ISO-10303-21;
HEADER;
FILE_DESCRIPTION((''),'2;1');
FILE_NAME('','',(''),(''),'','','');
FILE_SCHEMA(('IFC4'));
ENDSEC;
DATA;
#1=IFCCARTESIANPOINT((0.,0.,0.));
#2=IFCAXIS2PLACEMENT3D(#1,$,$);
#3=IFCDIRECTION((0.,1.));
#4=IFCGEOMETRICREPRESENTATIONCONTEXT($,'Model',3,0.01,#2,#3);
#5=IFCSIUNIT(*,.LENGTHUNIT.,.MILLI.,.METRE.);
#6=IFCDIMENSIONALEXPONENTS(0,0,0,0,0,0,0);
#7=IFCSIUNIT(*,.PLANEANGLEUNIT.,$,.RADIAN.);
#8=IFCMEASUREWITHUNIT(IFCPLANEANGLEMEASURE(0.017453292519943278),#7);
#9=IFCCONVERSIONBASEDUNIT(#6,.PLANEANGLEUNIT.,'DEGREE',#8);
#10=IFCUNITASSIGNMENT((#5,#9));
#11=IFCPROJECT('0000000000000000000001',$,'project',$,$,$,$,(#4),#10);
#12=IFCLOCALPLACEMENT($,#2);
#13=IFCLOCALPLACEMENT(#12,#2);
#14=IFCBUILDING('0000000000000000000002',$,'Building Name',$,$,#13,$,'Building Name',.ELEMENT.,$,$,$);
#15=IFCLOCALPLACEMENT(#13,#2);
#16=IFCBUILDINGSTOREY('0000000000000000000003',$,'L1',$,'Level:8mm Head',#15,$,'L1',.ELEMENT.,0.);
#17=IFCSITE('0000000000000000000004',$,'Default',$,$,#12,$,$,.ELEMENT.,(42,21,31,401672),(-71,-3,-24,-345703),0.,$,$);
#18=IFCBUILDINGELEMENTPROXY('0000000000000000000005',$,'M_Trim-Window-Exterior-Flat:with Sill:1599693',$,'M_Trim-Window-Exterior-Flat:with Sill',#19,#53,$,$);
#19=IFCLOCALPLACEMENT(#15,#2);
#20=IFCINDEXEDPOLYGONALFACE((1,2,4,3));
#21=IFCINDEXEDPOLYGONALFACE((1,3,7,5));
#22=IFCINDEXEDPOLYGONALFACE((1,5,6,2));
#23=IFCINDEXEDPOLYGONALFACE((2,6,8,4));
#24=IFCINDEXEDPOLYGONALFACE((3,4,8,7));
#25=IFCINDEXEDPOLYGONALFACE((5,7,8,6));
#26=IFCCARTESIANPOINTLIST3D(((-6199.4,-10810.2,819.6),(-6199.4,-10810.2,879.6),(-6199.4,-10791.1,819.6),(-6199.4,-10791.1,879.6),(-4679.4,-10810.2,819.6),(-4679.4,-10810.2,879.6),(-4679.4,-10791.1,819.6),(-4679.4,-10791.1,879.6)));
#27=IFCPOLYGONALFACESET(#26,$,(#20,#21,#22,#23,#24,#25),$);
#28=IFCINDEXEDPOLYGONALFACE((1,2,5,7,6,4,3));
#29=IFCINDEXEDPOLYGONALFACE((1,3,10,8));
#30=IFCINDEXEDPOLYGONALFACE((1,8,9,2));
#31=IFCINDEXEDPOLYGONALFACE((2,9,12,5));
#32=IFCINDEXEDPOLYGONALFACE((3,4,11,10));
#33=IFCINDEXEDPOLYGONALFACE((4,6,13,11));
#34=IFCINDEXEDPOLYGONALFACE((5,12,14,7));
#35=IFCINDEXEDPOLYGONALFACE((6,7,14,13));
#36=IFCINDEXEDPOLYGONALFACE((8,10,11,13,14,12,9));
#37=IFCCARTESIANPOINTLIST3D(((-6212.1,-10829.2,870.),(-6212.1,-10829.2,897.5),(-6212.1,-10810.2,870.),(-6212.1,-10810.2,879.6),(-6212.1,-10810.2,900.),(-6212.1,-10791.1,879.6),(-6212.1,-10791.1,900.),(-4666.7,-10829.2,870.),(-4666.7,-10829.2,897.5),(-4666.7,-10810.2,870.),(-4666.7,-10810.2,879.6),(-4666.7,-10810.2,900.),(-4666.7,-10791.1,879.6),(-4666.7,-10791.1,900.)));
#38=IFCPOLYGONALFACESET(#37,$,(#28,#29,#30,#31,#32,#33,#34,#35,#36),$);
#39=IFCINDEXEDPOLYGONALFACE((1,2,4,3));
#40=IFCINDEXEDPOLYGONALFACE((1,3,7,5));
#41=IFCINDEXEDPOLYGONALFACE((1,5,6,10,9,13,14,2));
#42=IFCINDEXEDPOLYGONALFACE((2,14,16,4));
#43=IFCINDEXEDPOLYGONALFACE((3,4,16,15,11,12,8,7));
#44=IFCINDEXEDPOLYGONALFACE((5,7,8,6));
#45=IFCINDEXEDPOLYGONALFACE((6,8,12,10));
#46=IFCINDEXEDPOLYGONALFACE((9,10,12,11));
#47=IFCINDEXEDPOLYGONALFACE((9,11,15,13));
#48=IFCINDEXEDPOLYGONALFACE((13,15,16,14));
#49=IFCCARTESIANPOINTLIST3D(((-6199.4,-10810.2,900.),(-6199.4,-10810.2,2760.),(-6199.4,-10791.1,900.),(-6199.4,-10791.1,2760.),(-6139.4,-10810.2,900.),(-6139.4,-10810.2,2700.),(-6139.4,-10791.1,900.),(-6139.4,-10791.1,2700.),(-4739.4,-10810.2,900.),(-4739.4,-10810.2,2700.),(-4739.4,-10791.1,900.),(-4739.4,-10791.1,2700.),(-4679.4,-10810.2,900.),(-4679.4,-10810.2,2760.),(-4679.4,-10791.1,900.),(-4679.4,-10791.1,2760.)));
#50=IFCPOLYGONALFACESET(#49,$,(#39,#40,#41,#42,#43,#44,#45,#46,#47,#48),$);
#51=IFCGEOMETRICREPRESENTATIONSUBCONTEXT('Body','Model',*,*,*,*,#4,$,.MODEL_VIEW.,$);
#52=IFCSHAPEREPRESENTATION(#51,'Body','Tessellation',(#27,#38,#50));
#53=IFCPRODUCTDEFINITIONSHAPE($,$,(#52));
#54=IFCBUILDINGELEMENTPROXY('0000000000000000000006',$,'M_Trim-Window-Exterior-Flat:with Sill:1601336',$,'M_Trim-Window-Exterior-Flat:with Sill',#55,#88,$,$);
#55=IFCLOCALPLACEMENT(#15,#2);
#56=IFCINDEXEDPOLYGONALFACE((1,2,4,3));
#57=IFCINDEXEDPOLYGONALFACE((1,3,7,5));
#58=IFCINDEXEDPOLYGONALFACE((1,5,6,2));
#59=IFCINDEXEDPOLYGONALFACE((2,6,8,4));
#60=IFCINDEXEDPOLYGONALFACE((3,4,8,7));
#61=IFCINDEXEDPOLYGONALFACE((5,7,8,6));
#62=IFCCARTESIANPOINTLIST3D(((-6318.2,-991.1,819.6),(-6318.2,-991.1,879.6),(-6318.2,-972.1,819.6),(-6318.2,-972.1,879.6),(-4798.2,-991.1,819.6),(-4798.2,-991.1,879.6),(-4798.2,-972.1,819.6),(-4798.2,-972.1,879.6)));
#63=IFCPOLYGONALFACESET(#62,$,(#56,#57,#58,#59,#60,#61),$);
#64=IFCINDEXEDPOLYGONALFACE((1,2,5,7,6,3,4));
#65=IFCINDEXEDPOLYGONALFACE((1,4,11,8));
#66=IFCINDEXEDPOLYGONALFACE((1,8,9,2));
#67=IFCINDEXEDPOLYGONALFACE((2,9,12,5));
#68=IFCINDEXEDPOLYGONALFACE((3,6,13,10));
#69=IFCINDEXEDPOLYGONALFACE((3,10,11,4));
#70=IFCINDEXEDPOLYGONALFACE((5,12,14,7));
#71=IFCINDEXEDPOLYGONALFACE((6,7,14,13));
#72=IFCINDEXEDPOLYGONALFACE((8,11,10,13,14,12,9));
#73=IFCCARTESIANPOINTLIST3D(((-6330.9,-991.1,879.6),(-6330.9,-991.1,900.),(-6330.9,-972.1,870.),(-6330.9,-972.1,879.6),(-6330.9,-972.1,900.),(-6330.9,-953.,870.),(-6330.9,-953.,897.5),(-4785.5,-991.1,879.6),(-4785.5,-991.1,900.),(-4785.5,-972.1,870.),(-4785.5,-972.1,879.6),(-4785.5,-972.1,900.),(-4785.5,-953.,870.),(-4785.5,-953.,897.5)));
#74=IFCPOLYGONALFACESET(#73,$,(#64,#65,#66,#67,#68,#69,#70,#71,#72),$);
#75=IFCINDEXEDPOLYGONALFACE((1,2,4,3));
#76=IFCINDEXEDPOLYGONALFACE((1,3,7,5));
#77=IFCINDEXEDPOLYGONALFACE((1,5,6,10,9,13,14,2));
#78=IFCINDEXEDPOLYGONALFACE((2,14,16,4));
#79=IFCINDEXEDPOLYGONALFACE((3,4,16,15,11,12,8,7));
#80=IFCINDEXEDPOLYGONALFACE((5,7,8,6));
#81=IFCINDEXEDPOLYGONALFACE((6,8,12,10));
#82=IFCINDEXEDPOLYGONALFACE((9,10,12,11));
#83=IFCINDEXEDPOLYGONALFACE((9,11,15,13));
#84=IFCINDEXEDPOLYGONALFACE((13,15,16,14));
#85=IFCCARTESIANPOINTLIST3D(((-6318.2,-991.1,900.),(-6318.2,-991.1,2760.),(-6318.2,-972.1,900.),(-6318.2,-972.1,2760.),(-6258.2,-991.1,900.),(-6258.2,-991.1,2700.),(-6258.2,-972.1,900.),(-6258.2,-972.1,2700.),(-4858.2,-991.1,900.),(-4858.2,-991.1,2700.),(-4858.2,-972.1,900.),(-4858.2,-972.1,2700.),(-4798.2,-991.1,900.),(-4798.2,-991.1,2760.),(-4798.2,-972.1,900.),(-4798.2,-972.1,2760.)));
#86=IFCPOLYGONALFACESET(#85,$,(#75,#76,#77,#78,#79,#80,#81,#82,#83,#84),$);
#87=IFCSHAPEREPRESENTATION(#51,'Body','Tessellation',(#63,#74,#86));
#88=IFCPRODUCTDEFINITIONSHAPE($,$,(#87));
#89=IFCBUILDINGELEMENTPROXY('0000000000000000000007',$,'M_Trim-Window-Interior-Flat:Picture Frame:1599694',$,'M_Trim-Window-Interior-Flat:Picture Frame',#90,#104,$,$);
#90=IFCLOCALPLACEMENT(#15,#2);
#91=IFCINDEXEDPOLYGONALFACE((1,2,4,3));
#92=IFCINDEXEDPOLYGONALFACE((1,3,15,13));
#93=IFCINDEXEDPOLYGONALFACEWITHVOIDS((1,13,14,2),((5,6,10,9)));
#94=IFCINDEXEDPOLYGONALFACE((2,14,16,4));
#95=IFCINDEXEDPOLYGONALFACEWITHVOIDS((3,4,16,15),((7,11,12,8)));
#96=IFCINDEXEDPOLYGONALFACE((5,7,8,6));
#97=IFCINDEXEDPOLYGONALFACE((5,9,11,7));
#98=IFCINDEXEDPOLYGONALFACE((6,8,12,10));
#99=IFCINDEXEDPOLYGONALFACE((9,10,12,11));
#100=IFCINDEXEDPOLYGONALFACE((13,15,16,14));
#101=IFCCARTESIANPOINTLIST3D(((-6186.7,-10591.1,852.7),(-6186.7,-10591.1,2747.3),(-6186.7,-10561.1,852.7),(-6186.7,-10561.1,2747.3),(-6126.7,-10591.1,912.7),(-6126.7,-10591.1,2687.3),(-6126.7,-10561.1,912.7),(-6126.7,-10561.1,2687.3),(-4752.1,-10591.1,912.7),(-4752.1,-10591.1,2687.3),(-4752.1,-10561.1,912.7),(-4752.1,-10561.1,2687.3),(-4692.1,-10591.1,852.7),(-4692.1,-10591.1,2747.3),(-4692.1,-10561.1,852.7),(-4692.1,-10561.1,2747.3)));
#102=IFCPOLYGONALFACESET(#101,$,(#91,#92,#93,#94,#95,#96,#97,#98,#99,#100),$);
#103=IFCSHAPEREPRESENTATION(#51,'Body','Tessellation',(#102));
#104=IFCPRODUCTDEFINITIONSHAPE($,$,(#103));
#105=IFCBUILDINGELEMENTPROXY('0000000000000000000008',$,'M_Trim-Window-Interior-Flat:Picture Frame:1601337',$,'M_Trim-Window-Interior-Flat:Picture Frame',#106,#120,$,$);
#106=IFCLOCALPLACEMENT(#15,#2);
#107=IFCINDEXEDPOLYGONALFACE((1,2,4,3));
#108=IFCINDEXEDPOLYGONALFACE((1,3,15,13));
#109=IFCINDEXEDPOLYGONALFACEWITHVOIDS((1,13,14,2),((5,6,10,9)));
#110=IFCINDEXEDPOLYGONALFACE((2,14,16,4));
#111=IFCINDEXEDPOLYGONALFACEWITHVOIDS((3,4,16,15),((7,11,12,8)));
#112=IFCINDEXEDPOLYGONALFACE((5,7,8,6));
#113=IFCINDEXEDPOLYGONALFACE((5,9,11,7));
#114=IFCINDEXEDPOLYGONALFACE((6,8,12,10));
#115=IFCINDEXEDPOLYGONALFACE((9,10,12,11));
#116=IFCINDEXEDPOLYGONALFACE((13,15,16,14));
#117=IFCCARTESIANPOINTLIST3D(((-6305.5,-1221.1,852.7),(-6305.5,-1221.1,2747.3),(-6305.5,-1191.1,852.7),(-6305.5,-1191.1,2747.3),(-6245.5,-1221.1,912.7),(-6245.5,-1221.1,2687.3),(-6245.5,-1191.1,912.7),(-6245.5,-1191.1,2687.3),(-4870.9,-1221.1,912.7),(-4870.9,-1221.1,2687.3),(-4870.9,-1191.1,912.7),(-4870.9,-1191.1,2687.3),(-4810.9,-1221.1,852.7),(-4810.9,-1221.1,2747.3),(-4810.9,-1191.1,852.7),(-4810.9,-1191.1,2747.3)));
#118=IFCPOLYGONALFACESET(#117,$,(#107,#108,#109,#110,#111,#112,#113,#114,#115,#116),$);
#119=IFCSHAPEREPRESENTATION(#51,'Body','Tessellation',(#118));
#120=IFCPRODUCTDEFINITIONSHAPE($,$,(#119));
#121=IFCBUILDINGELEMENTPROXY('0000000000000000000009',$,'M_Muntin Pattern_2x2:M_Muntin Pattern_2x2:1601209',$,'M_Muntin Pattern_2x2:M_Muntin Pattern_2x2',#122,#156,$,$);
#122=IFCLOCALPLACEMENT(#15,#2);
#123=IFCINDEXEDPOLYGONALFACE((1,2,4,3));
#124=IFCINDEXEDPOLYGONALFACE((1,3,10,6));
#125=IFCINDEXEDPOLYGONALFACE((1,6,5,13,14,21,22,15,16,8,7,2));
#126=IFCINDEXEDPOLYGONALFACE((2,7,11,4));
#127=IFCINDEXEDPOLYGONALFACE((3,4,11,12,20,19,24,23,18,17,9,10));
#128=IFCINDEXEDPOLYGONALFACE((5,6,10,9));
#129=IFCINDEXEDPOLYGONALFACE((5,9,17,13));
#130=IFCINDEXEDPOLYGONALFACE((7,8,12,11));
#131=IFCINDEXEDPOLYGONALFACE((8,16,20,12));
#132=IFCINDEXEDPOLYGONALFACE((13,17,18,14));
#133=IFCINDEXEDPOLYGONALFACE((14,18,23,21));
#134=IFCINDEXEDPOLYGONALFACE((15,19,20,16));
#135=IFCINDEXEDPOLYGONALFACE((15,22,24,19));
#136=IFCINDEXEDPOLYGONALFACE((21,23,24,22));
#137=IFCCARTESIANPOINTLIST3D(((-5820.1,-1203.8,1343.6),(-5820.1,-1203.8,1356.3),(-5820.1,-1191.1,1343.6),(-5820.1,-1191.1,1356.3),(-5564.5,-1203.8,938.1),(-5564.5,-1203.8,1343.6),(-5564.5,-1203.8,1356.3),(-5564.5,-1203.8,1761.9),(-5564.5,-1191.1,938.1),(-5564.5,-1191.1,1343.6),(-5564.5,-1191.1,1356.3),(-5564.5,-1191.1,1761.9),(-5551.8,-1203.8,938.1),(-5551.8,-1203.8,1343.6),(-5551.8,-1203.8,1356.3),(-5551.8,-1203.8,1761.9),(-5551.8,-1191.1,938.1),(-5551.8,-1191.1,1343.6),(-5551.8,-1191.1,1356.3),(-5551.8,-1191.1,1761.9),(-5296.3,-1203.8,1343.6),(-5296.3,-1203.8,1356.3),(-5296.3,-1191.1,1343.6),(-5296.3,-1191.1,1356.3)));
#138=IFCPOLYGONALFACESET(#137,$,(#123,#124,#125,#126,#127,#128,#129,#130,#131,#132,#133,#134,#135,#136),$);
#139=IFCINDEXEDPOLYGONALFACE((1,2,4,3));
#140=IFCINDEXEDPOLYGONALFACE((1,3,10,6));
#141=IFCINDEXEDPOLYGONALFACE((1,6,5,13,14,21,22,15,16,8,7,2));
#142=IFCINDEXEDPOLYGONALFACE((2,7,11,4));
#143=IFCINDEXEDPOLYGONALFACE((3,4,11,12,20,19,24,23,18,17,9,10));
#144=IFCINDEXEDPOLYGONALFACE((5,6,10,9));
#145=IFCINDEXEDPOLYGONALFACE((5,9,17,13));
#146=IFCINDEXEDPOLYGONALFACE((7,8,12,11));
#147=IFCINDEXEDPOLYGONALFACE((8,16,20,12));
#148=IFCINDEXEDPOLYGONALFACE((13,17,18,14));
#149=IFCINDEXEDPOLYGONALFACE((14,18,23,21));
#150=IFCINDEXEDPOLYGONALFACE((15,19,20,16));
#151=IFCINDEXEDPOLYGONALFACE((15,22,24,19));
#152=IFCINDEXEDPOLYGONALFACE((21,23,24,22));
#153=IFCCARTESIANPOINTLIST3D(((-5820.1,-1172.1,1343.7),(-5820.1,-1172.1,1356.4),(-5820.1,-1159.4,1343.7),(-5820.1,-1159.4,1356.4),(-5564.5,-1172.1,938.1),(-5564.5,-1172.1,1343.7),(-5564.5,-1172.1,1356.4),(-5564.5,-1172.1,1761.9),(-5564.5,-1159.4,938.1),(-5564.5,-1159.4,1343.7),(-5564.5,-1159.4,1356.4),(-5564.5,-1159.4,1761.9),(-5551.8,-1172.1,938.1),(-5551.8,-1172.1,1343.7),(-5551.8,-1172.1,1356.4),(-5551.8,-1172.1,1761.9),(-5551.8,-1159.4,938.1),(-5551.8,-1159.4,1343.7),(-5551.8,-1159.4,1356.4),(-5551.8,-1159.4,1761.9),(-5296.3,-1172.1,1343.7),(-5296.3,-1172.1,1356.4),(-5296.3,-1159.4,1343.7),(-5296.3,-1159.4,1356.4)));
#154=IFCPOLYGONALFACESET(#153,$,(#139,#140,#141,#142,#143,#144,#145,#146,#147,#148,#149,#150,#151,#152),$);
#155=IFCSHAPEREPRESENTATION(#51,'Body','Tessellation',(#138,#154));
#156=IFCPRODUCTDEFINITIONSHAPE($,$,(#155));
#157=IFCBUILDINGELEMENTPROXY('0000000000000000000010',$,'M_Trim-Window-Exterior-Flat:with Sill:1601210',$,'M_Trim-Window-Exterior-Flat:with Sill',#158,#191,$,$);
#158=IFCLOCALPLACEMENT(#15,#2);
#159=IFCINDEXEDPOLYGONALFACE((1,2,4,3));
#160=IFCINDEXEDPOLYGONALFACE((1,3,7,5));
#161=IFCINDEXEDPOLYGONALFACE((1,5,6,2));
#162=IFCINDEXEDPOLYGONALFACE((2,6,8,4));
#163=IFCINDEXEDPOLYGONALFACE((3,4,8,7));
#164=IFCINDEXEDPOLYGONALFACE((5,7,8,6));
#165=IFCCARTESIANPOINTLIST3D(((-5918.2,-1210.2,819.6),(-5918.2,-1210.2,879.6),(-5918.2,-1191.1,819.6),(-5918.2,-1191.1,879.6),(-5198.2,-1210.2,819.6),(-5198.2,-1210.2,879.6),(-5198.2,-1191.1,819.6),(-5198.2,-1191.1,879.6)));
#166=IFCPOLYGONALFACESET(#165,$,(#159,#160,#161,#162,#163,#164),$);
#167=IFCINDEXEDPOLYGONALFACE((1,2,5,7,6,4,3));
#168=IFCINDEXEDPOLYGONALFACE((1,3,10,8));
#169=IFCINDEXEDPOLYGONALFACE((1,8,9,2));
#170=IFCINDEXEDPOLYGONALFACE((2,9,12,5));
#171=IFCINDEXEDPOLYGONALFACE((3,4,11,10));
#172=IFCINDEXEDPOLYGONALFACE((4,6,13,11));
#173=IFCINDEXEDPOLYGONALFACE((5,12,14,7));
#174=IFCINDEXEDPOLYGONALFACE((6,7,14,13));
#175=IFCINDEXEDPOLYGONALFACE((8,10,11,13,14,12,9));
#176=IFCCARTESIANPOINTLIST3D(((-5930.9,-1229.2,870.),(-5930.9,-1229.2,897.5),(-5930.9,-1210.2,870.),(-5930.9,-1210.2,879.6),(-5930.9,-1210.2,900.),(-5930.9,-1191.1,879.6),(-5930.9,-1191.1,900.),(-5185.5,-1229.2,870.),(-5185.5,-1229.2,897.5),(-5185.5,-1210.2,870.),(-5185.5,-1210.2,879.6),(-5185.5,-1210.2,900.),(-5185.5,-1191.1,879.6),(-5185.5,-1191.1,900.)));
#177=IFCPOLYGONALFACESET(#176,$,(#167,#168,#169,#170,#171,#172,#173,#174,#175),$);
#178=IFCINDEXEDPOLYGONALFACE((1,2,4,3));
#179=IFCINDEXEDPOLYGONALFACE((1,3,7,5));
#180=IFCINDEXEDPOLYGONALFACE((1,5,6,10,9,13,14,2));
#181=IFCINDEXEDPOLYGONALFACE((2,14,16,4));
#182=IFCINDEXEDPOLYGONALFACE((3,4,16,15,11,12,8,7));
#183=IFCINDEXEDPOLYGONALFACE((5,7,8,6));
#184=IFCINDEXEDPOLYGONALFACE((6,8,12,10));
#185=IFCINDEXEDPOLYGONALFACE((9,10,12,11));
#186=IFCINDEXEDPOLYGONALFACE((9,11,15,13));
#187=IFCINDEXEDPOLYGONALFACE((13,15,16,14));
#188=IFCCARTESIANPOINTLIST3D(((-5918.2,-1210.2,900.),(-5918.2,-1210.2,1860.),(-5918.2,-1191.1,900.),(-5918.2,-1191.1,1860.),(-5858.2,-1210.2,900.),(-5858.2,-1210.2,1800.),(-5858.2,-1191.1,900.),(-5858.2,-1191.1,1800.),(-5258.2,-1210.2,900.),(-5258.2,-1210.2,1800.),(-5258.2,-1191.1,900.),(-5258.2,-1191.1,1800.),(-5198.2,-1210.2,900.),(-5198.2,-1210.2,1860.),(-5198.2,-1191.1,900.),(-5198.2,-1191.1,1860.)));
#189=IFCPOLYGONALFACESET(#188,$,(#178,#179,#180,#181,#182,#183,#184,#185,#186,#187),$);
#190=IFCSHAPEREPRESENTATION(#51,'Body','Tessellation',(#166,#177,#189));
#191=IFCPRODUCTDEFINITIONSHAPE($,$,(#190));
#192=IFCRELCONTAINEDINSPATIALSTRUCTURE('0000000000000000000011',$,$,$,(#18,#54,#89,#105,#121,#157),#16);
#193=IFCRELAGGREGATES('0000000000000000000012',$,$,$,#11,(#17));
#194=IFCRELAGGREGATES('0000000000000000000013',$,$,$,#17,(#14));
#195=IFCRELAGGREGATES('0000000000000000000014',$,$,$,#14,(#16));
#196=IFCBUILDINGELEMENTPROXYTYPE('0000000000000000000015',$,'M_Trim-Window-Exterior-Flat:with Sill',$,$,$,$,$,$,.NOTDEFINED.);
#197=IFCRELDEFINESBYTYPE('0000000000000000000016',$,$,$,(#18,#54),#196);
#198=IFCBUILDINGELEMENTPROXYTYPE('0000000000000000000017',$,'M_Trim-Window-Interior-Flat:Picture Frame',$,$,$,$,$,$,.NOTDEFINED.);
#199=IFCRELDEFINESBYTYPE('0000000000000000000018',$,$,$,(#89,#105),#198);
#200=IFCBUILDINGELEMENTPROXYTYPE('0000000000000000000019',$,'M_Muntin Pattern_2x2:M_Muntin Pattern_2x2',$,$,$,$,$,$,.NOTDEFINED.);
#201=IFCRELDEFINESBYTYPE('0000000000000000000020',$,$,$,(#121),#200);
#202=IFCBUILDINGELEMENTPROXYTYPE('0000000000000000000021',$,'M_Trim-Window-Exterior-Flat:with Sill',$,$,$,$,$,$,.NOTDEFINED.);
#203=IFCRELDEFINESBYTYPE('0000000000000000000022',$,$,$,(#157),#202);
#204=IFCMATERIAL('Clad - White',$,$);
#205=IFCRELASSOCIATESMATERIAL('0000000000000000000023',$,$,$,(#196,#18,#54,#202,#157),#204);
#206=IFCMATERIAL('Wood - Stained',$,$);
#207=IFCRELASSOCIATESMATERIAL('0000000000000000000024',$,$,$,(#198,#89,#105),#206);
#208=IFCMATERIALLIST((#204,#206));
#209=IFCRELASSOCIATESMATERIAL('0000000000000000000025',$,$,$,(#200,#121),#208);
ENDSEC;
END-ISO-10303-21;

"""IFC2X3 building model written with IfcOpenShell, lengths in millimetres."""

from ifc_helpers import new_model, entity, si_unit, converted_unit, direction, frame, frame_2d, origin, place, context, subcontext, project, spatial, polyline, rectangle, outline, extrude, source, transform, mapped, material, material_list, type_object, type_shapes, element, save


model = new_model("IFC2X3")

# Units and contexts
model_context = context("Model", 3, precision=0.01, world=origin(), true_north=direction((0.0, 1.0)))
body_context = subcontext(model_context, "Body", "Model", "MODEL_VIEW")
ifc_project = project(units=[si_unit("LENGTHUNIT", "METRE", prefix="MILLI"), converted_unit("PLANEANGLEUNIT", "DEGREE", entity("IfcPlaneAngleMeasure", 0.017453292519943278), si_unit("PLANEANGLEUNIT", "RADIAN"), dimensions=[0, 0, 0, 0, 0, 0, 0])], contexts=[model_context])

# Site, building, storey
site_placement = place(None, origin())
site = spatial("IfcSite", under=ifc_project, at=site_placement, Name="Default", CompositionType="ELEMENT", RefLatitude=(42, 21, 31, 401672), RefLongitude=(-71, -3, -24, -345703), RefElevation=0.0)
building_placement = place(site_placement, origin())
building = spatial("IfcBuilding", under=site, at=building_placement, Name="Building Name", LongName="Building Name", CompositionType="ELEMENT")
storey_placement = place(building_placement, origin())
storey = spatial("IfcBuildingStorey", under=building, at=storey_placement, Name="L1", ObjectType="Level:8mm Head", LongName="L1", CompositionType="ELEMENT", Elevation=0.0)

# Building element proxies
ifc_material_1 = material(Name="Clad - White")
ifc_material_2 = material(Name="Wood - Stained")
ifc_material_list = material_list([ifc_material_1, ifc_material_2])
building_element_proxy_type_1 = type_object("IfcBuildingElementProxyType", Name="M_Trim-Window-Exterior-Flat:with Sill", PredefinedType="NOTDEFINED", material=ifc_material_1)
shared_shape_1 = source(origin(), body_context, "Body", "SweptSolid", [
    extrude(rectangle(XDim=1520.0, YDim=60.0, at=frame_2d((0.0, 0.0), x_axis=(1.0, 0.0))), frame((0.0, -1850.4, 0.0), z_axis=(0.0, 0.0, 1.0), x_axis=(-1.0, 0.0, 0.0)), (0.0, 0.0, 1.0), 19.0),
    extrude(outline(polyline([(-19.0, -15.2), (0.0, -15.2), (0.0, -5.7), (19.0, -5.7), (19.0, 14.8), (0.0, 14.8), (-19.0, 12.3), (-19.0, -15.2)])), frame((-772.7, -1814.8, 19.0), z_axis=(1.0, 0.0, 0.0), x_axis=(0.0, 0.0, -1.0)), (0.0, 0.0, 1.0), 1545.4),
    extrude(outline(polyline([(-945.0, -760.0), (915.0, -760.0), (915.0, -700.0), (-885.0, -700.0), (-885.0, 700.0), (915.0, 700.0), (915.0, 760.0), (-945.0, 760.0), (-945.0, -760.0)])), frame((0.0, -885.0, 0.0), z_axis=(0.0, 0.0, 1.0), x_axis=(0.0, -1.0, 0.0)), (0.0, 0.0, 1.0), 19.0),
])
type_shapes(building_element_proxy_type_1, [shared_shape_1])
for number, where, z_axis, x_axis, name in (
    (1, (-5439.4, -10791.1, 2700.0), (0.0, -1.0, 0.0), (1.0, 0.0, 0.0), "M_Trim-Window-Exterior-Flat:with Sill:1599693"),
    (2, (-5558.2, -991.1, 2700.0), (0.0, 1.0, 0.0), (-1.0, 0.0, 0.0), "M_Trim-Window-Exterior-Flat:with Sill:1601336"),
):
    element("IfcBuildingElementProxy", number, at=place(storey_placement, frame(where, z_axis=z_axis, x_axis=x_axis)), inside=storey, type_object=building_element_proxy_type_1, material=ifc_material_1, Name=name, ObjectType="M_Trim-Window-Exterior-Flat:with Sill", context=body_context, shape_type="MappedRepresentation", body=[
        mapped(shared_shape_1, transform((0.0, 0.0, 0.0), scale=1.0)),
    ])
building_element_proxy_type_2 = type_object("IfcBuildingElementProxyType", Name="M_Trim-Window-Interior-Flat:Picture Frame", PredefinedType="NOTDEFINED", material=ifc_material_2)
shared_shape_2 = source(origin(), body_context, "Body", "SweptSolid", [
    extrude(outline(polyline([(-747.3, -947.3), (747.3, -947.3), (747.3, 947.3), (-747.3, 947.3), (-747.3, -947.3)]), holes=[polyline([(-687.3, -887.3), (-687.3, 887.3), (687.3, 887.3), (687.3, -887.3), (-687.3, -887.3)])]), frame((0.0, -900.0, 0.0), z_axis=(0.0, 0.0, 1.0), x_axis=(-1.0, 0.0, 0.0)), (0.0, 0.0, 1.0), 30.0),
])
type_shapes(building_element_proxy_type_2, [shared_shape_2])
for number, where, z_axis, x_axis, name in (
    (3, (-5439.4, -10591.1, 2700.0), (0.0, 1.0, 0.0), (-1.0, 0.0, 0.0), "M_Trim-Window-Interior-Flat:Picture Frame:1599694"),
    (4, (-5558.2, -1191.1, 2700.0), (0.0, -1.0, 0.0), (1.0, 0.0, 0.0), "M_Trim-Window-Interior-Flat:Picture Frame:1601337"),
):
    element("IfcBuildingElementProxy", number, at=place(storey_placement, frame(where, z_axis=z_axis, x_axis=x_axis)), inside=storey, type_object=building_element_proxy_type_2, material=ifc_material_2, Name=name, ObjectType="M_Trim-Window-Interior-Flat:Picture Frame", context=body_context, shape_type="MappedRepresentation", body=[
        mapped(shared_shape_2, transform((0.0, 0.0, 0.0), scale=1.0)),
    ])
building_element_proxy_type_3 = type_object("IfcBuildingElementProxyType", Name="M_Muntin Pattern_2x2:M_Muntin Pattern_2x2", PredefinedType="NOTDEFINED", material=ifc_material_list)
shared_shape_3 = source(origin(), body_context, "Body", "SweptSolid", [
    extrude(outline(polyline([(6.4, -6.4), (411.9, -6.4), (411.9, 6.3), (6.4, 6.3), (6.4, 261.9), (-6.3, 261.9), (-6.3, 6.3), (-411.9, 6.3), (-411.9, -6.4), (-6.3, -6.4), (-6.3, -261.9), (6.4, -261.9), (6.4, -6.4)])), frame((0.0, 9.5, 411.9), z_axis=(0.0, 1.0, 0.0), x_axis=(0.0, 0.0, 1.0)), (0.0, 0.0, 1.0), 12.7),
    extrude(outline(polyline([(6.4, -6.4), (411.9, -6.4), (411.9, 6.3), (6.4, 6.3), (6.4, 261.9), (-6.3, 261.9), (-6.3, 6.3), (-411.9, 6.3), (-411.9, -6.4), (-6.3, -6.4), (-6.3, -261.9), (6.4, -261.9), (6.4, -6.4)])), frame((0.0, -22.2, 411.9), z_axis=(0.0, 1.0, 0.0), x_axis=(0.0, 0.0, 1.0)), (0.0, 0.0, 1.0), 12.7),
])
type_shapes(building_element_proxy_type_3, [shared_shape_3])
proxy_1_placement = place(storey_placement, frame((-5558.2, -1181.6, 938.1), z_axis=(0.0, 0.0, 1.0), x_axis=(-1.0, 0.0, 0.0)))
element("IfcBuildingElementProxy", 5, at=proxy_1_placement, inside=storey, type_object=building_element_proxy_type_3, material=ifc_material_list, Name="M_Muntin Pattern_2x2:M_Muntin Pattern_2x2:1601209", ObjectType="M_Muntin Pattern_2x2:M_Muntin Pattern_2x2", context=body_context, shape_type="MappedRepresentation", body=[
    mapped(shared_shape_3, transform((0.0, 0.0, 0.0), scale=1.0)),
])
building_element_proxy_type_4 = type_object("IfcBuildingElementProxyType", Name="M_Trim-Window-Exterior-Flat:with Sill", PredefinedType="NOTDEFINED", material=ifc_material_1)
shared_shape_4 = source(origin(), body_context, "Body", "SweptSolid", [
    extrude(rectangle(XDim=60.0, YDim=720.0, at=frame_2d((0.0, 0.0), x_axis=(1.0, 0.0))), frame((0.0, 950.4, 0.0), z_axis=(0.0, 0.0, 1.0), x_axis=(0.0, 1.0, 0.0)), (0.0, 0.0, 1.0), 19.0),
    extrude(outline(polyline([(-15.2, -19.0), (12.3, -19.0), (14.8, 0.0), (14.8, 19.0), (-5.7, 19.0), (-5.7, 0.0), (-15.2, 0.0), (-15.2, -19.0)])), frame((-372.7, 914.8, 19.0), z_axis=(1.0, 0.0, 0.0), x_axis=(0.0, -1.0, 0.0)), (0.0, 0.0, 1.0), 745.4),
    extrude(outline(polyline([(-360.0, -495.0), (360.0, -495.0), (360.0, 465.0), (300.0, 465.0), (300.0, -435.0), (-300.0, -435.0), (-300.0, 465.0), (-360.0, 465.0), (-360.0, -495.0)])), frame((0.0, 435.0, 0.0)), (0.0, 0.0, 1.0), 19.0),
])
type_shapes(building_element_proxy_type_4, [shared_shape_4])
proxy_2_placement = place(storey_placement, frame((-5558.2, -1191.1, 1800.0), z_axis=(0.0, -1.0, 0.0), x_axis=(-1.0, 0.0, 0.0)))
element("IfcBuildingElementProxy", 6, at=proxy_2_placement, inside=storey, type_object=building_element_proxy_type_4, material=ifc_material_1, Name="M_Trim-Window-Exterior-Flat:with Sill:1601210", ObjectType="M_Trim-Window-Exterior-Flat:with Sill", context=body_context, shape_type="MappedRepresentation", body=[
    mapped(shared_shape_4, transform((0.0, 0.0, 0.0), scale=1.0)),
])

save(model, "model.ifc")
